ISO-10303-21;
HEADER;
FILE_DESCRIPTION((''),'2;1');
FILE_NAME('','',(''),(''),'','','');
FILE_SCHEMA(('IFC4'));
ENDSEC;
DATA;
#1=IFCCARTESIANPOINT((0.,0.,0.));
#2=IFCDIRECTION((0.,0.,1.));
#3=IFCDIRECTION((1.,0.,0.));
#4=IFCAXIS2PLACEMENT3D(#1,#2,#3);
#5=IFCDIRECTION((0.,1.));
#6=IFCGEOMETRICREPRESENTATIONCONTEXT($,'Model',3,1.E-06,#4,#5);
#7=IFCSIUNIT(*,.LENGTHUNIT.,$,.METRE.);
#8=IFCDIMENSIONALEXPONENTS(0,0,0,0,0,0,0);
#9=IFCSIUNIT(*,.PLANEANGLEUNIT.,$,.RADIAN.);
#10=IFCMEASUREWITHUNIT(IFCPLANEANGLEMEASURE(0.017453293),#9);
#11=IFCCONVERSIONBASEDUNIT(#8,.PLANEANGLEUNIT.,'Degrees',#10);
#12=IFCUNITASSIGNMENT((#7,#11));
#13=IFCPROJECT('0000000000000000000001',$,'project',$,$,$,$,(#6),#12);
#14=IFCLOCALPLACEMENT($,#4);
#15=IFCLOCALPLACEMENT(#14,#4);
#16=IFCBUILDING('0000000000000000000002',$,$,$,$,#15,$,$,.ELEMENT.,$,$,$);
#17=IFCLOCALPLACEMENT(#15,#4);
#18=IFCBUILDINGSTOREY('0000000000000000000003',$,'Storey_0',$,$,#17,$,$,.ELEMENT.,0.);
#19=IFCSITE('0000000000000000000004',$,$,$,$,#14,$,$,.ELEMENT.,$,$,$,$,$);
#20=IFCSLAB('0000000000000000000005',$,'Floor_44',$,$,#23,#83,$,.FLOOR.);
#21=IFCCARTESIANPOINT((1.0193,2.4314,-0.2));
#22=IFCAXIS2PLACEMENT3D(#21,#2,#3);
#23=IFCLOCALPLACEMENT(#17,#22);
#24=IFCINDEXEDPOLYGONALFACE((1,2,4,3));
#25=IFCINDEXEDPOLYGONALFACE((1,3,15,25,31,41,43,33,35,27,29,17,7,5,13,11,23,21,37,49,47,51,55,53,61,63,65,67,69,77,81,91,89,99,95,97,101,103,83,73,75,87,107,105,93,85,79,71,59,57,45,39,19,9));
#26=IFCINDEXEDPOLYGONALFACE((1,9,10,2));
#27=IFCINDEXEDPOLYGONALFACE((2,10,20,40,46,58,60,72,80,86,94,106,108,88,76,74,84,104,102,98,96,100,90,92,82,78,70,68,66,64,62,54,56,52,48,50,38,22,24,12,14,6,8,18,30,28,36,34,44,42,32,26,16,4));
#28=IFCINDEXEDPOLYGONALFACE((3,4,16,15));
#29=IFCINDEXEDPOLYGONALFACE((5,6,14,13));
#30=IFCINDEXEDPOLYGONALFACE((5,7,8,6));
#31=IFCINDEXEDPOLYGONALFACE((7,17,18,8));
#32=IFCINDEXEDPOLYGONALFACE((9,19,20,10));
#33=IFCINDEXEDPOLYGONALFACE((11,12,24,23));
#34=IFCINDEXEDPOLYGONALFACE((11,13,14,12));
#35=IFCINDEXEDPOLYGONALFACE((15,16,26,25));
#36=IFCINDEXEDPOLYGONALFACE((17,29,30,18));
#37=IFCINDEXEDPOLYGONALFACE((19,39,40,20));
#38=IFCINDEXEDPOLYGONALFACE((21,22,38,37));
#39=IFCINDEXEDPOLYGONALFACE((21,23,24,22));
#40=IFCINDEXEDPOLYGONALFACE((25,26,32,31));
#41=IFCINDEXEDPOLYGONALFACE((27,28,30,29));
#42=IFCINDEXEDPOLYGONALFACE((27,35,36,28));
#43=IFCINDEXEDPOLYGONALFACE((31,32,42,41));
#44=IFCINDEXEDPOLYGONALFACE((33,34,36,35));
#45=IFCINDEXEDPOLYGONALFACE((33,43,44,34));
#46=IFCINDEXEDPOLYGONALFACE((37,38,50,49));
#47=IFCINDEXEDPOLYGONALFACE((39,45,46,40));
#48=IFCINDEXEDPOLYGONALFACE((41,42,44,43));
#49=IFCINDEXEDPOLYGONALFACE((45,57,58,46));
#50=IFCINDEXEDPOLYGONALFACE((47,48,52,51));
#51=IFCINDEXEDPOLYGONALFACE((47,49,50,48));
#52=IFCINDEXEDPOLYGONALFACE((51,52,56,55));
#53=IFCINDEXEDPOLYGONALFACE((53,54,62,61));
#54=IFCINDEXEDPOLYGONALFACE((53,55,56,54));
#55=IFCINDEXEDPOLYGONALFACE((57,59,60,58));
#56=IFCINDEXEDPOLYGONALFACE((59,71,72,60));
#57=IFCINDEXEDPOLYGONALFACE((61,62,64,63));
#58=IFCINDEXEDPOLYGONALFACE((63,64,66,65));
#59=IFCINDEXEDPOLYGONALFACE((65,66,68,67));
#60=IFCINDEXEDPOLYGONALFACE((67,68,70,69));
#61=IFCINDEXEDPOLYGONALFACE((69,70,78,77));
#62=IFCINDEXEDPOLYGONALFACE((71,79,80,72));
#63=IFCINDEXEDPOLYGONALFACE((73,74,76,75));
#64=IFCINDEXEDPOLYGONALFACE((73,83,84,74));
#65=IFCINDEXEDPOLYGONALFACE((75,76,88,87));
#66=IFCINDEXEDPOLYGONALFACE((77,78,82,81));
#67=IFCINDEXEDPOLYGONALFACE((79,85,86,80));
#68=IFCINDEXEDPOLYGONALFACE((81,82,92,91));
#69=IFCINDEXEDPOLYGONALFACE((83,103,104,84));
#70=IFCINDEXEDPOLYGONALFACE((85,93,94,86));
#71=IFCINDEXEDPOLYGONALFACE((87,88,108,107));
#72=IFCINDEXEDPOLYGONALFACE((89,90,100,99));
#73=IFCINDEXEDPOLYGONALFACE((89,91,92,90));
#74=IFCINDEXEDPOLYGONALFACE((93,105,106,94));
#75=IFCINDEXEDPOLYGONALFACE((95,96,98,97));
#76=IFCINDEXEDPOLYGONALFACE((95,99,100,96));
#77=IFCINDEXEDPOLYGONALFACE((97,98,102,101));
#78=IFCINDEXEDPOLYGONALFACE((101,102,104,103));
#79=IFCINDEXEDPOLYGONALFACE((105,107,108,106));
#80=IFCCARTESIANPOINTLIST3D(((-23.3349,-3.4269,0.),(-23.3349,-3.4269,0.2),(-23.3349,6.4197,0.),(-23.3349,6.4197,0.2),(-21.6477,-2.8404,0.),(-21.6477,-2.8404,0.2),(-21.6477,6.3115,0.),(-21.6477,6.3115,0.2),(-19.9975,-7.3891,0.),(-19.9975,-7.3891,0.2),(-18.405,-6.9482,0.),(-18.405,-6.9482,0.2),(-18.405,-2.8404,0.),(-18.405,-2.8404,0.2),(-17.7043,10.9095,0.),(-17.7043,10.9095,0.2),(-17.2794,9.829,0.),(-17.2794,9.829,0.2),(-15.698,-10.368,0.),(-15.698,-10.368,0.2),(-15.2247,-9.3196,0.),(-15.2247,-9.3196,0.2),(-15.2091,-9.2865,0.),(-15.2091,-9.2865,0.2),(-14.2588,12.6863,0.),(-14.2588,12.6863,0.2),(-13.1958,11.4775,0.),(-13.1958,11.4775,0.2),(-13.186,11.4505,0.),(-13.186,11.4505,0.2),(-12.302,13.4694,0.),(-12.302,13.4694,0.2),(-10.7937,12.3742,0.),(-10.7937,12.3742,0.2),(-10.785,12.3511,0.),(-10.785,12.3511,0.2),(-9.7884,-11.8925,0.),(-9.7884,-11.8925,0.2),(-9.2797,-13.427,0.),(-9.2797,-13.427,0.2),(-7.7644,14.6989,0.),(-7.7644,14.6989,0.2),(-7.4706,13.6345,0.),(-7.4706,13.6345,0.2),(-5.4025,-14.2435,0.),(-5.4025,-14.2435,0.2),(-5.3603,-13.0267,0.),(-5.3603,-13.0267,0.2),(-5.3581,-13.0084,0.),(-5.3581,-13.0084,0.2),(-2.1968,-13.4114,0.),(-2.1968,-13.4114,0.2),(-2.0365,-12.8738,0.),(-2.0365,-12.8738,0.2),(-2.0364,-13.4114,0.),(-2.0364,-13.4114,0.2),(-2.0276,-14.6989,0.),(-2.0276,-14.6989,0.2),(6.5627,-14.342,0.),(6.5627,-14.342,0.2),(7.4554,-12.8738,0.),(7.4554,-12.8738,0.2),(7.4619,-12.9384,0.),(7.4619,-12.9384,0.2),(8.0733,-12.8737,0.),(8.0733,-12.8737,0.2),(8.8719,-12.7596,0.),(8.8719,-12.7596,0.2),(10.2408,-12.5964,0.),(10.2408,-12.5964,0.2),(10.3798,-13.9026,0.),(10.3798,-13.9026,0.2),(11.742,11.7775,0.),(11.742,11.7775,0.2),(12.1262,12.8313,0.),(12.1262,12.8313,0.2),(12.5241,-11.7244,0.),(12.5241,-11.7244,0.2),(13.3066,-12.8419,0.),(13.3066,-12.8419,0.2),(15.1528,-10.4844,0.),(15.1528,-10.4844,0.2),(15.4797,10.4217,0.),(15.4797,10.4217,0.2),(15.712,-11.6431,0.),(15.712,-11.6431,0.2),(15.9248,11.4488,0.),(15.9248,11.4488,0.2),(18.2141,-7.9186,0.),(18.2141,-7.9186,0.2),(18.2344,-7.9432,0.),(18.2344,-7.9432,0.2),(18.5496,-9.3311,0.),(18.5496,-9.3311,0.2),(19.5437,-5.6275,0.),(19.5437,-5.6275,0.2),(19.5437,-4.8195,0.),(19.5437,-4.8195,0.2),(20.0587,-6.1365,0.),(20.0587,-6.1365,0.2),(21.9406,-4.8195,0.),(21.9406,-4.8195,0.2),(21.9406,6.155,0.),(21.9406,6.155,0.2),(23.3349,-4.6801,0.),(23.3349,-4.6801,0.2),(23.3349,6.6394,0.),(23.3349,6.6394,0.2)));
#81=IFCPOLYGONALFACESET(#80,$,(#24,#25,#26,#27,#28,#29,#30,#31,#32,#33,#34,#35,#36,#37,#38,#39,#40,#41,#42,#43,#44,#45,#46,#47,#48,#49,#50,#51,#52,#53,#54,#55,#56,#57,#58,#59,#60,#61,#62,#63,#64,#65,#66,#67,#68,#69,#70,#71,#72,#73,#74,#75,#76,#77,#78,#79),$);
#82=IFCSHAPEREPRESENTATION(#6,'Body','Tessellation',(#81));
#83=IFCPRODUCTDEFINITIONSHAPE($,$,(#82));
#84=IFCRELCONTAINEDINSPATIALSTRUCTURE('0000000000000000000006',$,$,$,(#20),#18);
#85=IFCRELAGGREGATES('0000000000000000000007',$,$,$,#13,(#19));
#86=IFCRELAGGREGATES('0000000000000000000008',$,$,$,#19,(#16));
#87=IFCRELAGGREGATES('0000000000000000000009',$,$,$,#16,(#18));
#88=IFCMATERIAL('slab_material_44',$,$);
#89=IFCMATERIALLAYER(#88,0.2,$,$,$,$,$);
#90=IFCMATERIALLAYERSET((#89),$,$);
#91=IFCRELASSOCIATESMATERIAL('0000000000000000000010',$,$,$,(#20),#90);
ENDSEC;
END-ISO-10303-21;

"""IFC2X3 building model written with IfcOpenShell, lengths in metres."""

from ifc_helpers import new_model, entity, si_unit, converted_unit, direction, frame, origin_with_axes, place, context, project, spatial, polyline, outline, extrude, material, layer, layer_set, layer_usage, element, save


model = new_model("IFC2X3")

# Units and contexts
model_context = context("Model", 3, precision=1e-06, world=origin_with_axes(), true_north=direction((0.0, 1.0)))
ifc_project = project(units=[si_unit("LENGTHUNIT", "METRE"), converted_unit("PLANEANGLEUNIT", "Degrees", entity("IfcPlaneAngleMeasure", 0.017453293), si_unit("PLANEANGLEUNIT", "RADIAN"), dimensions=[0, 0, 0, 0, 0, 0, 0])], contexts=[model_context])

# Site, building, storey
site_placement = place(None, origin_with_axes())
site = spatial("IfcSite", under=ifc_project, at=site_placement, CompositionType="ELEMENT")
building_placement = place(site_placement, origin_with_axes())
building = spatial("IfcBuilding", under=site, at=building_placement, CompositionType="ELEMENT")
storey_placement = place(building_placement, origin_with_axes())
storey = spatial("IfcBuildingStorey", under=building, at=storey_placement, Name="Storey_0", CompositionType="ELEMENT", Elevation=0.0)

# Slab
ifc_material_1 = material(Name="slab_material_44")
ifc_layer_1 = layer(ifc_material_1, 0.2)
ifc_layer_set_1 = layer_set([ifc_layer_1])
ifc_layer_usage_1 = layer_usage(ifc_layer_set_1, "AXIS3", "POSITIVE", 0.0)
slab_1_placement = place(storey_placement, frame((1.0193, 2.4314, -0.2), z_axis=(0.0, 0.0, 1.0), x_axis=(1.0, 0.0, 0.0)))
element("IfcSlab", 1, at=slab_1_placement, inside=storey, material=ifc_layer_usage_1, Name="Floor_44", PredefinedType="FLOOR", context=model_context, shape_type="SweptSolid", body=[
    extrude(outline(polyline([(-18.405, -6.9482), (-15.2091, -9.2865), (-15.2247, -9.3196), (-9.7884, -11.8925), (-5.3581, -13.0084), (-5.3603, -13.0267), (-2.1968, -13.4114), (-2.0364, -13.4114), (-2.0365, -12.8738), (7.4554, -12.8738), (7.4619, -12.9384), (8.0733, -12.8737), (8.8719, -12.7596), (10.2408, -12.5964), (12.5241, -11.7244), (15.1528, -10.4844), (18.2344, -7.9432), (18.2141, -7.9186), (20.0587, -6.1365), (19.5437, -5.6275), (19.5437, -4.8195), (21.9406, -4.8195), (21.9406, 6.155), (15.4797, 10.4217), (11.742, 11.7775), (12.1262, 12.8313), (15.9248, 11.4488), (23.3349, 6.6394), (23.3349, -4.6801), (18.5496, -9.3311), (15.712, -11.6431), (13.3066, -12.8419), (10.3798, -13.9026), (6.5627, -14.342), (-2.0276, -14.6989), (-5.4025, -14.2435), (-9.2797, -13.427), (-15.698, -10.3681), (-19.9975, -7.3891), (-23.3349, -3.4269), (-23.3349, 6.4197), (-17.7043, 10.9095), (-14.2588, 12.6863), (-12.302, 13.4694), (-7.7644, 14.6989), (-7.4706, 13.6345), (-10.7937, 12.3742), (-10.785, 12.3511), (-13.1958, 11.4775), (-13.186, 11.4505), (-17.2794, 9.829), (-21.6477, 6.3115), (-21.6477, -2.8404), (-18.405, -2.8404), (-18.405, -6.9482)])), origin_with_axes(), (0.0, 0.0, 1.0), 0.2),
])

save(model, "model.ifc")
